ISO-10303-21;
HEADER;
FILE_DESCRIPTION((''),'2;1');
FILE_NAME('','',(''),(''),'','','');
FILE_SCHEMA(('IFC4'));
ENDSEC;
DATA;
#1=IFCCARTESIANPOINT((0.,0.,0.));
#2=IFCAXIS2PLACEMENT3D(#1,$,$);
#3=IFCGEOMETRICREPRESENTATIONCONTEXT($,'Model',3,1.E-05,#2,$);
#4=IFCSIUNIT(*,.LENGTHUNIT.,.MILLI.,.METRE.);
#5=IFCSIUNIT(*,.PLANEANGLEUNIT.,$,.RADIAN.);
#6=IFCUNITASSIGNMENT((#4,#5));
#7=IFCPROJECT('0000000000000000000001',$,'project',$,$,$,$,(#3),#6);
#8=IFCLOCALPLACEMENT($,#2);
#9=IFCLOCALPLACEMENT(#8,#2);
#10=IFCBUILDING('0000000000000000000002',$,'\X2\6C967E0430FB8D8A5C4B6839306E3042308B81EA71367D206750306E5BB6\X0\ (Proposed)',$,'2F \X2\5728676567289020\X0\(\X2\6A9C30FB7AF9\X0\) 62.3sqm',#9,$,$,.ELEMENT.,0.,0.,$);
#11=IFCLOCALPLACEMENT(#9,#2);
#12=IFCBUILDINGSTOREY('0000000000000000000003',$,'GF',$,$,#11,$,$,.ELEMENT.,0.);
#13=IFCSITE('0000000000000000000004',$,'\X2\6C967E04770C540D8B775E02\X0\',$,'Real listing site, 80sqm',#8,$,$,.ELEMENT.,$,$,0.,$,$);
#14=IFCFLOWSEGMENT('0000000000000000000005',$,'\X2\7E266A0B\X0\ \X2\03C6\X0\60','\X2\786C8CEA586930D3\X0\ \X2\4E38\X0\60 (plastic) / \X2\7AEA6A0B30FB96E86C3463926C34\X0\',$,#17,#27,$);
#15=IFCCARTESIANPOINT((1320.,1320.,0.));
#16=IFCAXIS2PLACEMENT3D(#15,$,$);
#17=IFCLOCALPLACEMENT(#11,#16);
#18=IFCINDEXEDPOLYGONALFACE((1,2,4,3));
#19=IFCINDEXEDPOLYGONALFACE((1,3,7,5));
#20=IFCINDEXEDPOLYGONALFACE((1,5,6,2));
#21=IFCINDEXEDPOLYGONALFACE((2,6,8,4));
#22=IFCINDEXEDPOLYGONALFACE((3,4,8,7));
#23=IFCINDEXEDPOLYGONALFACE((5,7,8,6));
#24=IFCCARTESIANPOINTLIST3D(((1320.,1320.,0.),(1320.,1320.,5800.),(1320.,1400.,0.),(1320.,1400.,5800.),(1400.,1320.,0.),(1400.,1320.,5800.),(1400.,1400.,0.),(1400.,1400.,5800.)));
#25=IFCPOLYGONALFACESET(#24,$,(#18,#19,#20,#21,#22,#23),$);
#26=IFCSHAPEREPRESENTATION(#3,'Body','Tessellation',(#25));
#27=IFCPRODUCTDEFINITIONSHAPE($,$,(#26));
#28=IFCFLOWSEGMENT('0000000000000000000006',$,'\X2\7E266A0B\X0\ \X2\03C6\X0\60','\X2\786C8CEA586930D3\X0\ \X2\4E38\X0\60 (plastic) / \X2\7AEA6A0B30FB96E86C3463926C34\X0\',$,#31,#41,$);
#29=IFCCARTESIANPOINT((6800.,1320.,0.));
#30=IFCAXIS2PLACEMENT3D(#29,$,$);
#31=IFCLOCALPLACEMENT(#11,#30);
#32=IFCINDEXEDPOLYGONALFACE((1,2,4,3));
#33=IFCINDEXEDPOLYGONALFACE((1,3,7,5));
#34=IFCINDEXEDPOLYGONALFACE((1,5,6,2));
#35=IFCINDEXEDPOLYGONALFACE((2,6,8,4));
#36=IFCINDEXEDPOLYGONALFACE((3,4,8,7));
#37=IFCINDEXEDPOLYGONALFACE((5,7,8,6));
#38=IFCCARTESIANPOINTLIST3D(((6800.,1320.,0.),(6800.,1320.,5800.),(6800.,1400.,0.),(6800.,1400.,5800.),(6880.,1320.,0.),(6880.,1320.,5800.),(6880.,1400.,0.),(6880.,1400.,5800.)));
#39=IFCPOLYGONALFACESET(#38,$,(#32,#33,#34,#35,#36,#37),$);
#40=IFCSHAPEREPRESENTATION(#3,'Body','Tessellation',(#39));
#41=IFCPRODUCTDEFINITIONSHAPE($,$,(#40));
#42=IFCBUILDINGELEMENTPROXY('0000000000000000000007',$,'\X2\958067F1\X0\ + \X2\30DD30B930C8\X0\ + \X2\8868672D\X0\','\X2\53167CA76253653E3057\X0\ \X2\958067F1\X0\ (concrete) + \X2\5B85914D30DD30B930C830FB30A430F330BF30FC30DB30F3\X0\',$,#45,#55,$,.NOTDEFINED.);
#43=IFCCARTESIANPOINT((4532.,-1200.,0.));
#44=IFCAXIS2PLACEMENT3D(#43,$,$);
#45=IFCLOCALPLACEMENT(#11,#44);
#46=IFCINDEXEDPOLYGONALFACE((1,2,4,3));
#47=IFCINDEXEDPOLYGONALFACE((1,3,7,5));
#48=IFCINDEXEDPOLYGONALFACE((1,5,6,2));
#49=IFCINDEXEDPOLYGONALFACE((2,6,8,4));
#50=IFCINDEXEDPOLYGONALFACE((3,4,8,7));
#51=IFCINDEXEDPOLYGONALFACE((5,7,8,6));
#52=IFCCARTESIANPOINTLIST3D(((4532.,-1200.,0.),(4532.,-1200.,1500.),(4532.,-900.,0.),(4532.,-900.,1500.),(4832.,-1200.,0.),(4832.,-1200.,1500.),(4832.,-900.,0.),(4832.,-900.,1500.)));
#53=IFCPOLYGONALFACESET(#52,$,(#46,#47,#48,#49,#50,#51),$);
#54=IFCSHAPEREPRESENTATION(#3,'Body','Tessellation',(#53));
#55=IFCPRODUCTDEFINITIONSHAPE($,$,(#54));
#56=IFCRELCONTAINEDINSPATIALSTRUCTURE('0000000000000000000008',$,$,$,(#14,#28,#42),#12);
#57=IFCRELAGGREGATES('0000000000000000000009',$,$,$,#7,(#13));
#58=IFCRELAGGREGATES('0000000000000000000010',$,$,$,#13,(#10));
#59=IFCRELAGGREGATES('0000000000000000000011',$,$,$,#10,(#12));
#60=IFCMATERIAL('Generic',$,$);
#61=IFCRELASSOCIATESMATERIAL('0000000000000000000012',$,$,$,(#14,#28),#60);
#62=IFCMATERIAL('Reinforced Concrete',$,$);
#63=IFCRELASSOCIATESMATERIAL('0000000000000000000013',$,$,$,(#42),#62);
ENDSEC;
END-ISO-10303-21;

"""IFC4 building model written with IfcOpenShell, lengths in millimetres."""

from ifc_helpers import new_model, si_unit, frame, frame_2d, origin, place, context, project, spatial, rectangle, extrude, material, element, save


model = new_model("IFC4")

# Units and contexts
model_context = context("Model", 3, precision=1e-05, world=origin())
ifc_project = project(units=[si_unit("LENGTHUNIT", "METRE", prefix="MILLI"), si_unit("PLANEANGLEUNIT", "RADIAN")], contexts=[model_context])

# Site, building, storey
site_placement = place(None, origin())
site = spatial("IfcSite", under=ifc_project, at=site_placement, Name="沖縄県名護市", ObjectType="Real listing site, 80sqm", CompositionType="ELEMENT", RefElevation=0.0)
building_placement = place(site_placement, origin())
building = spatial("IfcBuilding", under=site, at=building_placement, Name="沖縄・越屋根のある自然素材の家 (Proposed)", ObjectType="2F 在来木造(檜・竹) 62.3sqm", CompositionType="ELEMENT", ElevationOfRefHeight=0.0, ElevationOfTerrain=0.0)
storey_placement = place(building_placement, origin())
storey = spatial("IfcBuildingStorey", under=building, at=storey_placement, Name="GF", CompositionType="ELEMENT", Elevation=0.0)

# Shared definitions
ifc_material_1 = material(Name="Reinforced Concrete")

# Flow segments
ifc_material_2 = material(Name="Generic")
flow_segment_1_placement = place(storey_placement, frame((1320.0, 1320.0, 0.0)))
element("IfcFlowSegment", 1, at=flow_segment_1_placement, inside=storey, material=ifc_material_2, Name="縦樋 φ60", Description="硬質塩ビ 丸60 (plastic) / 竪樋・雨水排水", context=model_context, shape_type="SweptSolid", body=[
    extrude(rectangle(XDim=80.0, YDim=80.0, at=frame_2d((40.0, 40.0))), frame((1320.0, 1320.0, 0.0)), (0.0, 0.0, 1.0), 5800.0),
])
flow_segment_2_placement = place(storey_placement, frame((6800.0, 1320.0, 0.0)))
element("IfcFlowSegment", 2, at=flow_segment_2_placement, inside=storey, material=ifc_material_2, Name="縦樋 φ60", Description="硬質塩ビ 丸60 (plastic) / 竪樋・雨水排水", context=model_context, shape_type="SweptSolid", body=[
    extrude(rectangle(XDim=80.0, YDim=80.0, at=frame_2d((40.0, 40.0))), frame((6800.0, 1320.0, 0.0)), (0.0, 0.0, 1.0), 5800.0),
])

# Building element proxy
proxy_placement = place(storey_placement, frame((4532.0, -1200.0, 0.0)))
element("IfcBuildingElementProxy", 3, at=proxy_placement, inside=storey, material=ifc_material_1, Name="門柱 + ポスト + 表札", Description="化粧打放し 門柱 (concrete) + 宅配ポスト・インターホン", PredefinedType="NOTDEFINED", context=model_context, shape_type="SweptSolid", body=[
    extrude(rectangle(XDim=300.0, YDim=300.0, at=frame_2d((150.0, 150.0))), frame((4532.0, -1200.0, 0.0)), (0.0, 0.0, 1.0), 1500.0),
])

save(model, "model.ifc")
